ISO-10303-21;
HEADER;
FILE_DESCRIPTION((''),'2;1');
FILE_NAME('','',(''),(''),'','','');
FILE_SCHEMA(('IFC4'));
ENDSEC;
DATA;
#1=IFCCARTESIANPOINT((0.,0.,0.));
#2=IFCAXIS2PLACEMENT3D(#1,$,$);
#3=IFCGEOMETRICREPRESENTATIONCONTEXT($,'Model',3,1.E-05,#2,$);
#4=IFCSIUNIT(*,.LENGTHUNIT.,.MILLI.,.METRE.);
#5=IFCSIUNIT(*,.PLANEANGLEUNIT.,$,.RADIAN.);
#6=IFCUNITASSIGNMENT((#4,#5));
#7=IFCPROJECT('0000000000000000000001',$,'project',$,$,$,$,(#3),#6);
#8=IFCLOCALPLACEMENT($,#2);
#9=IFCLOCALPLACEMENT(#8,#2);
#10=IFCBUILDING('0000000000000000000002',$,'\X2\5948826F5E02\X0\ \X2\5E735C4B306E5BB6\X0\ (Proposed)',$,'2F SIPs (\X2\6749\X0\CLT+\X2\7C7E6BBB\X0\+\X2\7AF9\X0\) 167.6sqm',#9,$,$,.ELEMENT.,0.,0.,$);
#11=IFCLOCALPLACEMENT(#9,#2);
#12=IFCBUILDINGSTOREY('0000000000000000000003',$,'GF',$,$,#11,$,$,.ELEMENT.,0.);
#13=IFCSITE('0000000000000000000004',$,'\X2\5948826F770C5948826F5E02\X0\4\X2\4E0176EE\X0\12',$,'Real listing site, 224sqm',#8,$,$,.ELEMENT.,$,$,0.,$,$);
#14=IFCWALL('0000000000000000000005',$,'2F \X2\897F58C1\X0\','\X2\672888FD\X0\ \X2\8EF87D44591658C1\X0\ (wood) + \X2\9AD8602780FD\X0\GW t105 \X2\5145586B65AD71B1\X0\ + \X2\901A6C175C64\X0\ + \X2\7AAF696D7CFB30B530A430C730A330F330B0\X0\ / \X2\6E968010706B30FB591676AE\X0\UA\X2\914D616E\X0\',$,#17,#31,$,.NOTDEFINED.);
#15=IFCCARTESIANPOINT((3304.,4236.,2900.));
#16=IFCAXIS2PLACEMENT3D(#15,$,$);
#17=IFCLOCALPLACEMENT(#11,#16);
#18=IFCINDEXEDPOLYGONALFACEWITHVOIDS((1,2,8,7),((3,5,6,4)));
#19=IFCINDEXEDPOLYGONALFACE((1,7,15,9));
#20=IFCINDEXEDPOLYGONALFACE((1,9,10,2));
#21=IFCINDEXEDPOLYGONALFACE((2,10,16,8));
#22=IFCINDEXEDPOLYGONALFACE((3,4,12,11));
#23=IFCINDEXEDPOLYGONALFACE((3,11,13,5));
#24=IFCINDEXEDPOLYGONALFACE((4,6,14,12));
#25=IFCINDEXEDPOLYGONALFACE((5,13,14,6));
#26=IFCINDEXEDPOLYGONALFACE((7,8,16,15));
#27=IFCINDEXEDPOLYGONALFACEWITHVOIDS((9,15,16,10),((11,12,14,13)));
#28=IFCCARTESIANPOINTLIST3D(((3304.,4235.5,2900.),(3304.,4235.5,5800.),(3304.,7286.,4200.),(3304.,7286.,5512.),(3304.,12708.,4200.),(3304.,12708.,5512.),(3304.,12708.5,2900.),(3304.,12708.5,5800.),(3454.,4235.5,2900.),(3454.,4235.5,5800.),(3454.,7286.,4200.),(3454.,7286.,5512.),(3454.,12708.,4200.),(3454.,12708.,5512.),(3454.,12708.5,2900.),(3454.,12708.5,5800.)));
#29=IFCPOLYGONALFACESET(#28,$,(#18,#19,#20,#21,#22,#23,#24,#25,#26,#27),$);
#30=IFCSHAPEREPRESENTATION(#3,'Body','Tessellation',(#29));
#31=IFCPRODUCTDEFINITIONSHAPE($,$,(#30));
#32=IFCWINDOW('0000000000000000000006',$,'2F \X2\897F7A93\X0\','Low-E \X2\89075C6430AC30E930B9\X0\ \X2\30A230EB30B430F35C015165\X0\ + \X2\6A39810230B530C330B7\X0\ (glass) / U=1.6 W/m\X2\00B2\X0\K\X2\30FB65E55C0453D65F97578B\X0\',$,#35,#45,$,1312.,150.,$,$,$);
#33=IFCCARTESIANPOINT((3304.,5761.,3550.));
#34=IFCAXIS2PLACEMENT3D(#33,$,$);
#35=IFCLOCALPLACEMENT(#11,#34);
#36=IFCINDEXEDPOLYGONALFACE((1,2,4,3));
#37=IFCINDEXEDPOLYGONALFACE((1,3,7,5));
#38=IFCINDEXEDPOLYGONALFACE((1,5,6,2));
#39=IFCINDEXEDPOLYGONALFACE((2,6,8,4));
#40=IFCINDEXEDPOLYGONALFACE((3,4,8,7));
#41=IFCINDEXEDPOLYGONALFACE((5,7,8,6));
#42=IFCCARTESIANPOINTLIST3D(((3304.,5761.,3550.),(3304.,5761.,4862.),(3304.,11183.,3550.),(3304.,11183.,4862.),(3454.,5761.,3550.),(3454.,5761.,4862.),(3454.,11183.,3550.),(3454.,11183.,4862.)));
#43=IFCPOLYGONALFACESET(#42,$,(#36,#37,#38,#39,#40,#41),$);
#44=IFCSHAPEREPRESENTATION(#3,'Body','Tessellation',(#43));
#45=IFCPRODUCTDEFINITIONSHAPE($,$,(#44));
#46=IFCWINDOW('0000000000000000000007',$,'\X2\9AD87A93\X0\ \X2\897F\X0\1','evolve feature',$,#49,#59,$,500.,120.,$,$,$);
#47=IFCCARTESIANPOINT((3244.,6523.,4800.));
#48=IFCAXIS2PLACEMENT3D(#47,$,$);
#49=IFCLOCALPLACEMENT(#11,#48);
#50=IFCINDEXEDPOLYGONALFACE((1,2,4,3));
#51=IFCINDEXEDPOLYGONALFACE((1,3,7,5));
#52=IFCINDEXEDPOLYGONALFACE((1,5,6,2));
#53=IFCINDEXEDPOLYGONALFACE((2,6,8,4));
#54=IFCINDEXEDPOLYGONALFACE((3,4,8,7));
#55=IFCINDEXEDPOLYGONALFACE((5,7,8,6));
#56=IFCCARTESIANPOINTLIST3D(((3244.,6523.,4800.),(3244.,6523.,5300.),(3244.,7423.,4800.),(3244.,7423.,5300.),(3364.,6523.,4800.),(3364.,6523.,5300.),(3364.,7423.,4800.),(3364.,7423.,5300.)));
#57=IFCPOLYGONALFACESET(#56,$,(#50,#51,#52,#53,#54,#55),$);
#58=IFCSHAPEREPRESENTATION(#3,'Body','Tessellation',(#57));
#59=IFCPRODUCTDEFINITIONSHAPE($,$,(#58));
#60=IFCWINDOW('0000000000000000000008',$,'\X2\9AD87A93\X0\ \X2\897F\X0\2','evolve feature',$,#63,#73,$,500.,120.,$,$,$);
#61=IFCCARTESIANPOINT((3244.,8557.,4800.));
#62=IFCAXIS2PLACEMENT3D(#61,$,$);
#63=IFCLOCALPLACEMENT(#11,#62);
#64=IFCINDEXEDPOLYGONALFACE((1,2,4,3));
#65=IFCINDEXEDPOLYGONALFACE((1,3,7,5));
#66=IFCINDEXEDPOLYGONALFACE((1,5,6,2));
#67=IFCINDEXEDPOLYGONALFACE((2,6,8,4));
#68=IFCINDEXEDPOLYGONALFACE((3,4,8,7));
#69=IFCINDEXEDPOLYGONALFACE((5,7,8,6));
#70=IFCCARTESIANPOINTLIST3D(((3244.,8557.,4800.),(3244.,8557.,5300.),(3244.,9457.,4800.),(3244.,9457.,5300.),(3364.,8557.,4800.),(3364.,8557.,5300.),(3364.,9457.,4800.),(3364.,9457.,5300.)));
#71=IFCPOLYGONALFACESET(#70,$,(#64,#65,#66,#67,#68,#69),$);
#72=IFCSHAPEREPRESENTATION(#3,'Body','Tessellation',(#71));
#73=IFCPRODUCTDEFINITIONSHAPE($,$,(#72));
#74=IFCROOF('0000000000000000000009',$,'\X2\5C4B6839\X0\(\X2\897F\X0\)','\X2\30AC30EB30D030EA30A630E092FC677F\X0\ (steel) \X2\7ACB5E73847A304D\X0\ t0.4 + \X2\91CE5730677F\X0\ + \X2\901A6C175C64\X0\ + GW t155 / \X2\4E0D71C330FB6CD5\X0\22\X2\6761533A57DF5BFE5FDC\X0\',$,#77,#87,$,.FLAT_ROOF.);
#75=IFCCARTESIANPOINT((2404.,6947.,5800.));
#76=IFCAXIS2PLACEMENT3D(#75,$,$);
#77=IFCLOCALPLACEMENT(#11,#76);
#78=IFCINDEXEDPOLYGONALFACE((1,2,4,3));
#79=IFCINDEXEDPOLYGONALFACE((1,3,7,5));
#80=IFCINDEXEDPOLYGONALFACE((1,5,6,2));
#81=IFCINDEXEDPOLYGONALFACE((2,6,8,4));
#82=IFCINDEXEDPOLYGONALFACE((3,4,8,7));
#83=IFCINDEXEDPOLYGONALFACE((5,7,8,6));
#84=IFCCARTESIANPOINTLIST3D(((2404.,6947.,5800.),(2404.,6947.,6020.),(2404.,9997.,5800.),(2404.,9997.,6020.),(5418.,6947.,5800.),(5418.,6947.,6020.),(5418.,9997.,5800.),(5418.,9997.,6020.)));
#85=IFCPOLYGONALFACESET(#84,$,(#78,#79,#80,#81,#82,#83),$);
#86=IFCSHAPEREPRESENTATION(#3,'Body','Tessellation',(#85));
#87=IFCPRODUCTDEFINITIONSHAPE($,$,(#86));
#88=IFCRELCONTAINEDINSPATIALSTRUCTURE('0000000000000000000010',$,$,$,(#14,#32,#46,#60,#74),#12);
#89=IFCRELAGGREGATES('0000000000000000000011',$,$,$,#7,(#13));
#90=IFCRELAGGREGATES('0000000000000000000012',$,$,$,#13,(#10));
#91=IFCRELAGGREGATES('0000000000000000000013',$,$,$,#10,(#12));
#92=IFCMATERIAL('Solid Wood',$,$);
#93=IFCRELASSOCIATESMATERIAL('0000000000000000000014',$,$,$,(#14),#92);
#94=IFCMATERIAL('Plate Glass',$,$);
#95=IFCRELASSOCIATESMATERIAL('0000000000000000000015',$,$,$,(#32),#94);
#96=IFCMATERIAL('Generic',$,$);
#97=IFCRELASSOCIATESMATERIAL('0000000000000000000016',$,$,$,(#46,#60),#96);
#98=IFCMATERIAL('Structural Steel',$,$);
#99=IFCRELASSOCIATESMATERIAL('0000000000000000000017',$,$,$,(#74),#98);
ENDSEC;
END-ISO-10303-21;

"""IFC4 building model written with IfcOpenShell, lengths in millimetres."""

from ifc_helpers import new_model, si_unit, frame, frame_2d, origin, place, context, project, spatial, rectangle, extrude, material, element, fill, save


model = new_model("IFC4")

# Units and contexts
model_context = context("Model", 3, precision=1e-05, world=origin())
ifc_project = project(units=[si_unit("LENGTHUNIT", "METRE", prefix="MILLI"), si_unit("PLANEANGLEUNIT", "RADIAN")], contexts=[model_context])

# Site, building, storey
site_placement = place(None, origin())
site = spatial("IfcSite", under=ifc_project, at=site_placement, Name="奈良県奈良市4丁目12", ObjectType="Real listing site, 224sqm", CompositionType="ELEMENT", RefElevation=0.0)
building_placement = place(site_placement, origin())
building = spatial("IfcBuilding", under=site, at=building_placement, Name="奈良市 平屋の家 (Proposed)", ObjectType="2F SIPs (杉CLT+籾殻+竹) 167.6sqm", CompositionType="ELEMENT", ElevationOfRefHeight=0.0, ElevationOfTerrain=0.0)
storey_placement = place(building_placement, origin())
storey = spatial("IfcBuildingStorey", under=building, at=storey_placement, Name="GF", CompositionType="ELEMENT", Elevation=0.0)

# Shared definitions
ifc_material_1 = material(Name="Solid Wood")
ifc_material_2 = material(Name="Generic")

# Shared definitions
ifc_material_3 = material(Name="Plate Glass")

# Wall, openings, windows
wall_1_placement = place(storey_placement, frame((3304.0, 4236.0, 2900.0)))
wall_1 = element("IfcWall", 1, at=wall_1_placement, inside=storey, material=ifc_material_1, Name="2F 西壁", Description="木製 軸組外壁 (wood) + 高性能GW t105 充填断熱 + 通気層 + 窯業系サイディング / 準耐火・外皮UA配慮", PredefinedType="NOTDEFINED", context=model_context, shape_type="SweptSolid", body=[
    extrude(rectangle(XDim=150.0, YDim=8473.0, at=frame_2d((75.0, 4236.0))), frame((3304.0, 4236.0, 2900.0)), (0.0, 0.0, 1.0), 2900.0),
])
opening_1_placement = place(storey_placement, frame((3304.0, 5761.0, 3550.0)))
opening_1 = element("IfcOpeningElement", 2, at=opening_1_placement, cuts=wall_1, PredefinedType="NOTDEFINED", context=model_context, shape_type="SweptSolid", body=[
    extrude(rectangle(XDim=150.0, YDim=5422.0, at=frame_2d((75.0, 2711.0))), frame((3304.0, 5761.0, 3550.0)), (0.0, 0.0, 1.0), 1312.0),
])
opening_2_placement = place(storey_placement, frame((3244.0, 6523.0, 4800.0)))
opening_2 = element("IfcOpeningElement", 3, at=opening_2_placement, cuts=wall_1, PredefinedType="NOTDEFINED", context=model_context, shape_type="SweptSolid", body=[
    extrude(rectangle(XDim=120.0, YDim=900.0, at=frame_2d((60.0, 450.0))), frame((3244.0, 6523.0, 4800.0)), (0.0, 0.0, 1.0), 500.0),
])
opening_3_placement = place(storey_placement, frame((3244.0, 8557.0, 4800.0)))
opening_3 = element("IfcOpeningElement", 4, at=opening_3_placement, cuts=wall_1, PredefinedType="NOTDEFINED", context=model_context, shape_type="SweptSolid", body=[
    extrude(rectangle(XDim=120.0, YDim=900.0, at=frame_2d((60.0, 450.0))), frame((3244.0, 8557.0, 4800.0)), (0.0, 0.0, 1.0), 500.0),
])
window_1_placement = place(storey_placement, frame((3304.0, 5761.0, 3550.0)))
window_1 = element("IfcWindow", 5, at=window_1_placement, inside=storey, material=ifc_material_3, Name="2F 西窓", Description="Low-E 複層ガラス アルゴン封入 + 樹脂サッシ (glass) / U=1.6 W/m²K・日射取得型", OverallHeight=1312.0, OverallWidth=150.0, context=model_context, shape_type="SweptSolid", body=[
    extrude(rectangle(XDim=150.0, YDim=5422.0, at=frame_2d((75.0, 2711.0))), frame((3304.0, 5761.0, 3550.0)), (0.0, 0.0, 1.0), 1312.0),
])
fill(opening_1, window_1)
window_2_placement = place(storey_placement, frame((3244.0, 6523.0, 4800.0)))
window_2 = element("IfcWindow", 6, at=window_2_placement, inside=storey, material=ifc_material_2, Name="高窓 西1", Description="evolve feature", OverallHeight=500.0, OverallWidth=120.0, context=model_context, shape_type="SweptSolid", body=[
    extrude(rectangle(XDim=120.0, YDim=900.0, at=frame_2d((60.0, 450.0))), frame((3244.0, 6523.0, 4800.0)), (0.0, 0.0, 1.0), 500.0),
])
fill(opening_2, window_2)
window_3_placement = place(storey_placement, frame((3244.0, 8557.0, 4800.0)))
window_3 = element("IfcWindow", 7, at=window_3_placement, inside=storey, material=ifc_material_2, Name="高窓 西2", Description="evolve feature", OverallHeight=500.0, OverallWidth=120.0, context=model_context, shape_type="SweptSolid", body=[
    extrude(rectangle(XDim=120.0, YDim=900.0, at=frame_2d((60.0, 450.0))), frame((3244.0, 8557.0, 4800.0)), (0.0, 0.0, 1.0), 500.0),
])
fill(opening_3, window_3)

# Roof
ifc_material_4 = material(Name="Structural Steel")
roof_1_placement = place(storey_placement, frame((2404.0, 6947.0, 5800.0)))
element("IfcRoof", 8, at=roof_1_placement, inside=storey, material=ifc_material_4, Name="屋根(西)", Description="ガルバリウム鋼板 (steel) 立平葺き t0.4 + 野地板 + 通気層 + GW t155 / 不燃・法22条区域対応", PredefinedType="FLAT_ROOF", context=model_context, shape_type="SweptSolid", body=[
    extrude(rectangle(XDim=3014.0, YDim=3050.0, at=frame_2d((1507.0, 1525.0))), frame((2404.0, 6947.0, 5800.0)), (0.0, 0.0, 1.0), 220.0),
])

save(model, "model.ifc")
